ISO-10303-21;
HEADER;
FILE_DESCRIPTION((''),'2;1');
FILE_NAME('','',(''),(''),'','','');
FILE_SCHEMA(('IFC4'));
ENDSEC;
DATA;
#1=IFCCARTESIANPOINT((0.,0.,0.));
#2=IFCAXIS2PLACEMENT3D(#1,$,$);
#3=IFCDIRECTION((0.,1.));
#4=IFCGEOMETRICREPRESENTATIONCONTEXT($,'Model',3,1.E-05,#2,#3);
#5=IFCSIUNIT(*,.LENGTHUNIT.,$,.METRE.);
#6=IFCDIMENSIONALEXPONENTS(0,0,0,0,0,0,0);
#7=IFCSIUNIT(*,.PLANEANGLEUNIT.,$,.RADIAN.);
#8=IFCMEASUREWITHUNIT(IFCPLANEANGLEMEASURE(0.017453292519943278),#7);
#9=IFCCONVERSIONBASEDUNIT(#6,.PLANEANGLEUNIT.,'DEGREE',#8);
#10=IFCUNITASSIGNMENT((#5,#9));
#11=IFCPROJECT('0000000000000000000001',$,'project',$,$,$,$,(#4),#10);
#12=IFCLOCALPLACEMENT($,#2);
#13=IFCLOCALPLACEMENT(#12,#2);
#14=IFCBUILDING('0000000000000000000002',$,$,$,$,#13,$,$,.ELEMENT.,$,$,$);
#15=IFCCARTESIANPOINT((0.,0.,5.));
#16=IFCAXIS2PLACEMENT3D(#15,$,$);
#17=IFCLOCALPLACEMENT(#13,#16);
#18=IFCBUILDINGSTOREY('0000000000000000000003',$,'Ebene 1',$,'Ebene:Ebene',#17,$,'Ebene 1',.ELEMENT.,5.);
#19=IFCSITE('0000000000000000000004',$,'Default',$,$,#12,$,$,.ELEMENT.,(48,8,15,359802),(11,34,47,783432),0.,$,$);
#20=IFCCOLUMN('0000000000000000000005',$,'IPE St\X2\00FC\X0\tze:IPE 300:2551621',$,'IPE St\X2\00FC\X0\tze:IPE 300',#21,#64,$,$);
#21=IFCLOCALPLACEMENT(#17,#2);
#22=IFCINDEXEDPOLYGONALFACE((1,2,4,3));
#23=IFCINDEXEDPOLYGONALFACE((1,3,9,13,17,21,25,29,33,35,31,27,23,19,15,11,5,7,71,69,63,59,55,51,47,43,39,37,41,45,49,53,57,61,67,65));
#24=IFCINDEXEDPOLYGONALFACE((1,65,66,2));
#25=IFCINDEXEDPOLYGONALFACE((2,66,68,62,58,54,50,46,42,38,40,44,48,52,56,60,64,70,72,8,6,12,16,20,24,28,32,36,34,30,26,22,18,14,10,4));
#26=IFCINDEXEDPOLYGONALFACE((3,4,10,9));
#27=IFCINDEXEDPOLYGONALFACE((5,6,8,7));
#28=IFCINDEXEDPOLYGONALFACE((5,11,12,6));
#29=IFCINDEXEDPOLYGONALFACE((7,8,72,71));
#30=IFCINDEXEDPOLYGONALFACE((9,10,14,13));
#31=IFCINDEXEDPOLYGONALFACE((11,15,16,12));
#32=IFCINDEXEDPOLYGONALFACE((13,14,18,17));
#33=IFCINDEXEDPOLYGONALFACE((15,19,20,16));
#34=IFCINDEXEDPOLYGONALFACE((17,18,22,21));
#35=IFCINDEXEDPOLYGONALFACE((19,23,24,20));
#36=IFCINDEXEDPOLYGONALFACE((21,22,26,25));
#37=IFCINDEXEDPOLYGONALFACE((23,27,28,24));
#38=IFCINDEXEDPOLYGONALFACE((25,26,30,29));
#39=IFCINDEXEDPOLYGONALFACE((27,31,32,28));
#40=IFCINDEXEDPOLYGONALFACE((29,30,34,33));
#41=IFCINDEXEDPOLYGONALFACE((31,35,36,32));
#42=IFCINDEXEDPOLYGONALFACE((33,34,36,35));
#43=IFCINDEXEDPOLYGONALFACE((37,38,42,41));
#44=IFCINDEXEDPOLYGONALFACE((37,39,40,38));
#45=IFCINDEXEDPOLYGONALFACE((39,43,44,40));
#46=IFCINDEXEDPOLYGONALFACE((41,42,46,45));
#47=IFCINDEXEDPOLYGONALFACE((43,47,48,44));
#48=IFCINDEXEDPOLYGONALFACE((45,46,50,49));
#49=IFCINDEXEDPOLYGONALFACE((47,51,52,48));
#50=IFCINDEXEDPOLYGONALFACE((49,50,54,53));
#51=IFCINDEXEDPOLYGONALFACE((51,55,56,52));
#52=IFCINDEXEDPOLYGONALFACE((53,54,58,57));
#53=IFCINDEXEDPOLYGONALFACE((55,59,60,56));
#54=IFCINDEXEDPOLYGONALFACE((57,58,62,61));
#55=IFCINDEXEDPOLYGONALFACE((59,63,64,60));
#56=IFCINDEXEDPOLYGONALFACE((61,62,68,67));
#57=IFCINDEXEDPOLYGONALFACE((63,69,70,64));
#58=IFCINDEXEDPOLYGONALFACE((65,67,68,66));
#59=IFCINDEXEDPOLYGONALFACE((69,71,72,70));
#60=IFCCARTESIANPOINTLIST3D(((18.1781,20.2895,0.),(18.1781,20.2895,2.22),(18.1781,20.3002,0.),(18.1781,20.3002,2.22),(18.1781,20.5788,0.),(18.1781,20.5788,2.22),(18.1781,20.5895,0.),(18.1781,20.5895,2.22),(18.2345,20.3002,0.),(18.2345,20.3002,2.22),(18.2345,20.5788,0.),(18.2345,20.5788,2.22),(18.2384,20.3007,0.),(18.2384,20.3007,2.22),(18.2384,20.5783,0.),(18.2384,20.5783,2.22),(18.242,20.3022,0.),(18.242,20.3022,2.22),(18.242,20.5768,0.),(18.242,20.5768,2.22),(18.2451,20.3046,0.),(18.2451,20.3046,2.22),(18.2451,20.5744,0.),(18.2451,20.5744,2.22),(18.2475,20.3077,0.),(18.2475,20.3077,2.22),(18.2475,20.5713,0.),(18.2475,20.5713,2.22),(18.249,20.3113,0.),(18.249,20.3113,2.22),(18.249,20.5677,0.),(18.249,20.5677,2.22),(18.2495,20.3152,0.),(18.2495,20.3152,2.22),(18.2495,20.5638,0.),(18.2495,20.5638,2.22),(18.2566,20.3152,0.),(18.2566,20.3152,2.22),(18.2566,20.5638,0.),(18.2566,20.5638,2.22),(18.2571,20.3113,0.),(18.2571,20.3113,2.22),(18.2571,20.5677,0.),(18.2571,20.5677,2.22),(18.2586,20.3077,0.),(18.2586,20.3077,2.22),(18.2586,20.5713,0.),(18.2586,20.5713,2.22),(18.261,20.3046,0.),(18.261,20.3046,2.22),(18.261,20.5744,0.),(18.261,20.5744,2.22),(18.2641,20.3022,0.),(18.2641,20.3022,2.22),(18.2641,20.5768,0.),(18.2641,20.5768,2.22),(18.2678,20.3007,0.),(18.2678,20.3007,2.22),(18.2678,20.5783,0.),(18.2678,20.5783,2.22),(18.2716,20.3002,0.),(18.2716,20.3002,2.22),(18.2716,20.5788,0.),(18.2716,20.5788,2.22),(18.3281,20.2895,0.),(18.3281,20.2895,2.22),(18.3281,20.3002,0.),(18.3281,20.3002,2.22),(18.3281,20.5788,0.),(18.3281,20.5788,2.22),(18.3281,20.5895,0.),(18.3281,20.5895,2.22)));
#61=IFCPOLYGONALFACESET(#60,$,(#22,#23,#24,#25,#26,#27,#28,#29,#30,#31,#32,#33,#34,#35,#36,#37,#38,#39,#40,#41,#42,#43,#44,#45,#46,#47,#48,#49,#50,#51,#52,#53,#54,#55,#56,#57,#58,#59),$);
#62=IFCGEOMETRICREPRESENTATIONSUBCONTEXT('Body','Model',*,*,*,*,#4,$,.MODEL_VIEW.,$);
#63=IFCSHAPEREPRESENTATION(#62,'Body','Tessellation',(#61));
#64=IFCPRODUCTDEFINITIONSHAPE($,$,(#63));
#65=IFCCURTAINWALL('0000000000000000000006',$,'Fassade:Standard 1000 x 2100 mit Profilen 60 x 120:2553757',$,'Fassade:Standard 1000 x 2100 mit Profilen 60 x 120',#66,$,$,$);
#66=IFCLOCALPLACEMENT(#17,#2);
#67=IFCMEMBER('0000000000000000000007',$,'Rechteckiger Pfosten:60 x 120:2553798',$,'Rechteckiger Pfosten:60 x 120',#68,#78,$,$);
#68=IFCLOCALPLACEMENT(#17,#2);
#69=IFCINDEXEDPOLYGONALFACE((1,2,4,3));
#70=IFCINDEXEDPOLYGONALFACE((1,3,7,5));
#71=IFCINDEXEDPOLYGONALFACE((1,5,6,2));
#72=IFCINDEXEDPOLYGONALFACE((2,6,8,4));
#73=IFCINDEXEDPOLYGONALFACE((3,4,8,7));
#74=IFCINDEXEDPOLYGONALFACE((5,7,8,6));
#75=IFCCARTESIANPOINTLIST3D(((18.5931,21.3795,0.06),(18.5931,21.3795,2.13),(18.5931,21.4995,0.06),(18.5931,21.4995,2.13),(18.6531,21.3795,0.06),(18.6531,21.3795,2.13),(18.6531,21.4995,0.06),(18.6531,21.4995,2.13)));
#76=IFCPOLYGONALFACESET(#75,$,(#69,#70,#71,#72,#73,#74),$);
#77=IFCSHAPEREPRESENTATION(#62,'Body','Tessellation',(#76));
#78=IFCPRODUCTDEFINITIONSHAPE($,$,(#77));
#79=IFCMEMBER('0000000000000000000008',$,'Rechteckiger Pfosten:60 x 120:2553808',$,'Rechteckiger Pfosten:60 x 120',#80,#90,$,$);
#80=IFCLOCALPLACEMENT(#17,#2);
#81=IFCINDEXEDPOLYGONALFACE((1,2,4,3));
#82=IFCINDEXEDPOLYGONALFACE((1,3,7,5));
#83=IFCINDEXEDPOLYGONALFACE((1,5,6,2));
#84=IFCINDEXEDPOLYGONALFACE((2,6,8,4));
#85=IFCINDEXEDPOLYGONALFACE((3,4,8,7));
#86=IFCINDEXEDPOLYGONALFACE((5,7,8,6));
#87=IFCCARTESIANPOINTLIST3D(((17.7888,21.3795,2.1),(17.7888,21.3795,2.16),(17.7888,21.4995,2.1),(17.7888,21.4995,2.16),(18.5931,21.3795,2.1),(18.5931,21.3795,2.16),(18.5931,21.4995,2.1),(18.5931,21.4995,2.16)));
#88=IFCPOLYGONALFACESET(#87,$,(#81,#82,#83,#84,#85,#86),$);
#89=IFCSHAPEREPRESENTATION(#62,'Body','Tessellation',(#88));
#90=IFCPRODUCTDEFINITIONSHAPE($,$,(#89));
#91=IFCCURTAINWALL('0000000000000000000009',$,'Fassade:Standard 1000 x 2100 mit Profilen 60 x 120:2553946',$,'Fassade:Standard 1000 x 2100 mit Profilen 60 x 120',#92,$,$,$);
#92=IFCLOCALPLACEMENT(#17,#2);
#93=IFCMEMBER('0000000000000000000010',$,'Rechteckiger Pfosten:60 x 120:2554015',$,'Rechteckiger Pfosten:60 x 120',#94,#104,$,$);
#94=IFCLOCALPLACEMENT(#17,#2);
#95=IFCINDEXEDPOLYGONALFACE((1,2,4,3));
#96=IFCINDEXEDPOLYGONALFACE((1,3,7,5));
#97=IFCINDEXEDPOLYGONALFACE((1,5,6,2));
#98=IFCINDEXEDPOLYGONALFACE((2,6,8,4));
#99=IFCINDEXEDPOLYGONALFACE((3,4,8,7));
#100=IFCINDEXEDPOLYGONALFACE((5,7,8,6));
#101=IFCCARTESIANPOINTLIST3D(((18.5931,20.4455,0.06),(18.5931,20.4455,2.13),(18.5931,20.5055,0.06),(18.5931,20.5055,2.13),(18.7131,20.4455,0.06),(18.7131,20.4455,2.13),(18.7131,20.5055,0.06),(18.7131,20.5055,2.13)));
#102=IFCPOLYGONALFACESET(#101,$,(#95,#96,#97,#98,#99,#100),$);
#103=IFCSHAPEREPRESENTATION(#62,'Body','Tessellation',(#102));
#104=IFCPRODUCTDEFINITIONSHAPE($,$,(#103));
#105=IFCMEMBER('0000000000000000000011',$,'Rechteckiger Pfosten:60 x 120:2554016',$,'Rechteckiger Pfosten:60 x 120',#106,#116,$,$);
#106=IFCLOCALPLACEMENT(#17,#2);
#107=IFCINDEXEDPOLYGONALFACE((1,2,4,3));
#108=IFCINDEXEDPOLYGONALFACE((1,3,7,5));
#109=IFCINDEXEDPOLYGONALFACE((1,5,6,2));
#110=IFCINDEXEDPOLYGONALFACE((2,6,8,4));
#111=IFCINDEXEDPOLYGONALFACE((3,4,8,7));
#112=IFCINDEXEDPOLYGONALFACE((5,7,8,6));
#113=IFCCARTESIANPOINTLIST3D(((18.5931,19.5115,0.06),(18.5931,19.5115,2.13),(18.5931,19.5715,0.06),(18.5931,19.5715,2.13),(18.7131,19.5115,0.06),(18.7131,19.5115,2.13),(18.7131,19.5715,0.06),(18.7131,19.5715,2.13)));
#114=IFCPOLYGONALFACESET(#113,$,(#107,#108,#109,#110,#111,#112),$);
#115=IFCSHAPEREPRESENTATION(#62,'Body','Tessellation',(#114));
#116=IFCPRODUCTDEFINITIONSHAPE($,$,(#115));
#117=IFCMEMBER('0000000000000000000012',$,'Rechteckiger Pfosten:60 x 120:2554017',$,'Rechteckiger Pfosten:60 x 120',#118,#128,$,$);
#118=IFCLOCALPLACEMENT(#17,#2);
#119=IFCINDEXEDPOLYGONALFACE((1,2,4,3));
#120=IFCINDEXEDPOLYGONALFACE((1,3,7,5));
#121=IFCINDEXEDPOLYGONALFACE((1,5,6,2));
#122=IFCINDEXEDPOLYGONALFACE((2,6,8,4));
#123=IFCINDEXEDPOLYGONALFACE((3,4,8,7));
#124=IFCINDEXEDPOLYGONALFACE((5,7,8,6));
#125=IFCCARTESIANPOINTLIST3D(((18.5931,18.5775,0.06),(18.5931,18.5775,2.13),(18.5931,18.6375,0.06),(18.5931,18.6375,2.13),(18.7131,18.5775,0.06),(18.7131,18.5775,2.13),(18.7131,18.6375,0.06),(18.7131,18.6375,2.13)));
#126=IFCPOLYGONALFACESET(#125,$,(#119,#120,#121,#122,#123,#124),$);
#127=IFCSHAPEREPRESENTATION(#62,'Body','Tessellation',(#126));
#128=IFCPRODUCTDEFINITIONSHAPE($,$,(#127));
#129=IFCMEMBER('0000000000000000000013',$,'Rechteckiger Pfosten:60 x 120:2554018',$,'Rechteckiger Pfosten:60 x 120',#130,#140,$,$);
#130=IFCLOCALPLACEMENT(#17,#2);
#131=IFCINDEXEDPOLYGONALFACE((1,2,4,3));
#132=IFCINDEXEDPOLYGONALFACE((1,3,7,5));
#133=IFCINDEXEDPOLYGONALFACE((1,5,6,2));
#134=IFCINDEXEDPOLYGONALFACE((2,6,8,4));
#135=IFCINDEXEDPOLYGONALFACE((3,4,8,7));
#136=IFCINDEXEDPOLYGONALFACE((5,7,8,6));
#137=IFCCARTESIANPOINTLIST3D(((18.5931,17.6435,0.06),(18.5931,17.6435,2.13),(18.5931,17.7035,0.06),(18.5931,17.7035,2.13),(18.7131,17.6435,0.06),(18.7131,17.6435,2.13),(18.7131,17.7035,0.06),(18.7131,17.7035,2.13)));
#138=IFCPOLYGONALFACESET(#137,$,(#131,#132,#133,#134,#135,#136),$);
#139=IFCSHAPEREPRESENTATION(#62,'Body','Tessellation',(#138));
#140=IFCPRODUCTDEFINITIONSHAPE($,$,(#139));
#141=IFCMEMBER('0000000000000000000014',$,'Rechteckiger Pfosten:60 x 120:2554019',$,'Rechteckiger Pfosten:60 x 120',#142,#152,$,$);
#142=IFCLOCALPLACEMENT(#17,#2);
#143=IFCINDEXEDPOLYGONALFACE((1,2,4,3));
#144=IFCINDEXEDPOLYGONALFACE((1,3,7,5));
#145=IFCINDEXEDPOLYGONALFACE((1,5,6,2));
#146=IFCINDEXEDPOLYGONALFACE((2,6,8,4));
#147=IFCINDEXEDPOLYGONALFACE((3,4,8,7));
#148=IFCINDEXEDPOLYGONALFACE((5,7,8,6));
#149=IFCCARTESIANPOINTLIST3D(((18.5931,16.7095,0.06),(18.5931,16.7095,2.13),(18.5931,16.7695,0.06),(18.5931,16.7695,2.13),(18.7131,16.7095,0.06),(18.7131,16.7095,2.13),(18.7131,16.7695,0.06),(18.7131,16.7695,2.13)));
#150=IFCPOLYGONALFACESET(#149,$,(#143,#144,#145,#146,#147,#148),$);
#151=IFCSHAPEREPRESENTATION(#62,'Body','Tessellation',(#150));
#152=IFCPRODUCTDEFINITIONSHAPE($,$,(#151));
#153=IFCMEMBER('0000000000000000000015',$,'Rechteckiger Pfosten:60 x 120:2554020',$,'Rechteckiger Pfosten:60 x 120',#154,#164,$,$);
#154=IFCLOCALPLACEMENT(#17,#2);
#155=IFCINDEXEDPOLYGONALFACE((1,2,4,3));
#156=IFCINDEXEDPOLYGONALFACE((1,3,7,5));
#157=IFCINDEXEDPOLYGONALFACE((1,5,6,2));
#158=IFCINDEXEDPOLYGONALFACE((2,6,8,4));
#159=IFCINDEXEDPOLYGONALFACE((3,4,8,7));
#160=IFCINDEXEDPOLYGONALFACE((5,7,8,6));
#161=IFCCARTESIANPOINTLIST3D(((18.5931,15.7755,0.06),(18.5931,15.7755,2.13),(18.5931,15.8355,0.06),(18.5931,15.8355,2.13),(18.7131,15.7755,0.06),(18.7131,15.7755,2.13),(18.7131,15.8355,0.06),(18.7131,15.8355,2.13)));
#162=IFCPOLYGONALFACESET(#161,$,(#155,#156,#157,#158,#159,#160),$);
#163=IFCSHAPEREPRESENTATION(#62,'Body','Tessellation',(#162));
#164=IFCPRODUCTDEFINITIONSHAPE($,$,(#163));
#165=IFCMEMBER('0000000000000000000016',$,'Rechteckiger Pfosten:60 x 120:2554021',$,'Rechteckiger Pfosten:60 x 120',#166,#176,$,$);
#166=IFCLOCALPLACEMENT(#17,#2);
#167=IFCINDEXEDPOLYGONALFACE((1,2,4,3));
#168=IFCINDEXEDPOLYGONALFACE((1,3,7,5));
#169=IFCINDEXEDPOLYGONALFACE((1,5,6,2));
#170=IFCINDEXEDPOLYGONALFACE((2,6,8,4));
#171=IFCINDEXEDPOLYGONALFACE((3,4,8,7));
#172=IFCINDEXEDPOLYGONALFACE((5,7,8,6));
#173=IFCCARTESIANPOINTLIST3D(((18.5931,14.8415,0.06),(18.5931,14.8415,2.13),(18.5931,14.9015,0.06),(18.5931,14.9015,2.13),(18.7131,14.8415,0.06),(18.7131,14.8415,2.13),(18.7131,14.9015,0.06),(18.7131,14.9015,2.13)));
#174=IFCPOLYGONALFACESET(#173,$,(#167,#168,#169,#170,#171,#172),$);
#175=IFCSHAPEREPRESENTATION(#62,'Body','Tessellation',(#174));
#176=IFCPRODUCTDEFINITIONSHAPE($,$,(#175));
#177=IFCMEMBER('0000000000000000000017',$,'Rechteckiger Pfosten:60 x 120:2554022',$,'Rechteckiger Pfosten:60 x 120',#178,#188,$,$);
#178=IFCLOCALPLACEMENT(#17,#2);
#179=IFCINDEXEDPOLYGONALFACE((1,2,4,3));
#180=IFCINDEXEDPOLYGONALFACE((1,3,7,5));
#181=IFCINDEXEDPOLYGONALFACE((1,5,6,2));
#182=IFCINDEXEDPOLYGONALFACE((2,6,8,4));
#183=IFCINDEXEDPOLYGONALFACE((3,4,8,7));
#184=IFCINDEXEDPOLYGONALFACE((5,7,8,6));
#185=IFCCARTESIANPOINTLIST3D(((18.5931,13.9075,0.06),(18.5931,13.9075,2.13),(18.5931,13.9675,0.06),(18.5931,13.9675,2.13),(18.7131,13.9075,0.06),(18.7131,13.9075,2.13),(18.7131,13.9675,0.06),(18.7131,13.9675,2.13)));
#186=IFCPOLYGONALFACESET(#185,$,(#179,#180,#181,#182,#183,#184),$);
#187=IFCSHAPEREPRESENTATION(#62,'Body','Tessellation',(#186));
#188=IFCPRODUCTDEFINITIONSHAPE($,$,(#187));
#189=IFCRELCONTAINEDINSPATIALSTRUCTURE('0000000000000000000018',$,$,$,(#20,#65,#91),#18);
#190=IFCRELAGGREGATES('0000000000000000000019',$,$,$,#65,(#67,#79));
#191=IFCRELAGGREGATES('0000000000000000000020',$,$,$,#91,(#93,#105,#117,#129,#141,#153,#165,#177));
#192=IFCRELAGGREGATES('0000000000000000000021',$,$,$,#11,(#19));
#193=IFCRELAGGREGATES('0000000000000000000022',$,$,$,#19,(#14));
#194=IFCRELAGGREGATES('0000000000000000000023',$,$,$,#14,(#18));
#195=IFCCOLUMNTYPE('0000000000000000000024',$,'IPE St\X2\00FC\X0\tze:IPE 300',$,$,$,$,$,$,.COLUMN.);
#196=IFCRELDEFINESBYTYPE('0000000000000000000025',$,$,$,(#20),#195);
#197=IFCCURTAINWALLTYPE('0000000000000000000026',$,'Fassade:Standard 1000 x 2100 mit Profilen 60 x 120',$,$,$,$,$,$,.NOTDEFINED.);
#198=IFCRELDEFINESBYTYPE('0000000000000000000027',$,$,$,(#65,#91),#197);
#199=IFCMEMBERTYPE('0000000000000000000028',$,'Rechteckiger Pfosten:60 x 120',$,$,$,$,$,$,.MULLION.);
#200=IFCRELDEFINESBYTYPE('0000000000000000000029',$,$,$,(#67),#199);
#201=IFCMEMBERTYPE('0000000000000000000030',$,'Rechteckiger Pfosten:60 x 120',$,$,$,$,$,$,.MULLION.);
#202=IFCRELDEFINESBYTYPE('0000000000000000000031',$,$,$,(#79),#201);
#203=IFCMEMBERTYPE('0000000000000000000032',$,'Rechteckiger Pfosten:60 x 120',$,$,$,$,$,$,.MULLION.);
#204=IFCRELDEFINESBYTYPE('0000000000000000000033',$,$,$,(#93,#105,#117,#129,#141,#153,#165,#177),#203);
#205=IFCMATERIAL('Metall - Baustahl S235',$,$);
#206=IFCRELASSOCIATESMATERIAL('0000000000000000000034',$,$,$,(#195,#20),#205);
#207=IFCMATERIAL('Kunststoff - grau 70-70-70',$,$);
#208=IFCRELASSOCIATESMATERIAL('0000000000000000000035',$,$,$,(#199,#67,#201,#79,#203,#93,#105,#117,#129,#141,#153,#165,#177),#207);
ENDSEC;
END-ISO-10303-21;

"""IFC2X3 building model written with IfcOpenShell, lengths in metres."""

from ifc_helpers import new_model, entity, si_unit, converted_unit, direction, frame, frame_2d, origin, origin_2d_with_axis, place, context, subcontext, project, spatial, rectangle, i_section, extrude, source, transform, mapped, material, type_object, type_shapes, element, aggregate, save


model = new_model("IFC2X3")

# Units and contexts
model_context = context("Model", 3, precision=1e-05, world=origin(), true_north=direction((0.0, 1.0)))
body_context = subcontext(model_context, "Body", "Model", "MODEL_VIEW")
ifc_project = project(units=[si_unit("LENGTHUNIT", "METRE"), converted_unit("PLANEANGLEUNIT", "DEGREE", entity("IfcPlaneAngleMeasure", 0.017453292519943278), si_unit("PLANEANGLEUNIT", "RADIAN"), dimensions=[0, 0, 0, 0, 0, 0, 0])], contexts=[model_context])

# Site, building, storey
site_placement = place(None, origin())
site = spatial("IfcSite", under=ifc_project, at=site_placement, Name="Default", CompositionType="ELEMENT", RefLatitude=(48, 8, 15, 359802), RefLongitude=(11, 34, 47, 783432), RefElevation=0.0)
building_placement = place(site_placement, origin())
building = spatial("IfcBuilding", under=site, at=building_placement, CompositionType="ELEMENT")
storey_placement = place(building_placement, frame((0.0, 0.0, 5.0)))
storey = spatial("IfcBuildingStorey", under=building, at=storey_placement, Name="Ebene 1", ObjectType="Ebene:Ebene", LongName="Ebene 1", CompositionType="ELEMENT", Elevation=5.0)

# Column
ifc_material_1 = material(Name="Metall - Baustahl S235")
column_type = type_object("IfcColumnType", Name="IPE Stütze:IPE 300", PredefinedType="COLUMN", material=ifc_material_1)
shared_shape_1 = source(origin(), body_context, "Body", "SweptSolid", [
    extrude(i_section(OverallWidth=0.15, OverallDepth=0.3, WebThickness=0.0071, FlangeThickness=0.0107, FilletRadius=0.015, at=origin_2d_with_axis()), frame((0.0, 0.0, 5.0), z_axis=(0.0, 0.0, 1.0), x_axis=(-1.0, 0.0, 0.0)), (0.0, 0.0, 1.0), 2.22),
])
type_shapes(column_type, [shared_shape_1])
column_placement = place(storey_placement, frame((18.2531, 20.4395, -5.0)))
element("IfcColumn", 1, at=column_placement, inside=storey, type_object=column_type, material=ifc_material_1, Name="IPE Stütze:IPE 300:2551621", ObjectType="IPE Stütze:IPE 300", context=body_context, shape_type="MappedRepresentation", body=[
    mapped(shared_shape_1, transform((0.0, 0.0, 0.0), scale=1.0)),
])

# Curtain walls, members
curtain_wall_type = type_object("IfcCurtainWallType", Name="Fassade:Standard 1000 x 2100 mit Profilen 60 x 120", PredefinedType="NOTDEFINED")
curtain_wall_1_placement = place(storey_placement, frame((0.0, 0.0, -5.0)))
curtain_wall_1 = element("IfcCurtainWall", 2, at=curtain_wall_1_placement, inside=storey, type_object=curtain_wall_type, Name="Fassade:Standard 1000 x 2100 mit Profilen 60 x 120:2553757", ObjectType="Fassade:Standard 1000 x 2100 mit Profilen 60 x 120")
ifc_material_2 = material(Name="Kunststoff - grau 70-70-70")
member_type_1 = type_object("IfcMemberType", Name="Rechteckiger Pfosten:60 x 120", PredefinedType="MULLION", material=ifc_material_2)
shared_shape_2 = source(origin(), body_context, "Body", "SweptSolid", [
    extrude(rectangle(XDim=0.06, YDim=0.12, at=origin_2d_with_axis()), frame((-0.03, 0.0, -2.07), z_axis=(0.0, 0.0, 1.0), x_axis=(-1.0, 0.0, 0.0)), (0.0, 0.0, 1.0), 2.07),
])
type_shapes(member_type_1, [shared_shape_2])
member_1_placement = place(curtain_wall_1_placement, frame((18.6531, 21.4395, 5.06), z_axis=(0.0, 0.0, -1.0), x_axis=(1.0, 0.0, 0.0)))
member_1 = element("IfcMember", 3, at=member_1_placement, type_object=member_type_1, material=ifc_material_2, Name="Rechteckiger Pfosten:60 x 120:2553798", ObjectType="Rechteckiger Pfosten:60 x 120", context=body_context, shape_type="MappedRepresentation", body=[
    mapped(shared_shape_2, transform((0.0, 0.0, 0.0), scale=1.0)),
])
member_type_2 = type_object("IfcMemberType", Name="Rechteckiger Pfosten:60 x 120", PredefinedType="MULLION", material=ifc_material_2)
shared_shape_3 = source(origin(), body_context, "Body", "SweptSolid", [
    extrude(rectangle(XDim=0.06, YDim=0.12, at=frame_2d((0.0, 0.0), x_axis=(1.0, 0.0))), frame((0.0, 0.0, -0.8043), z_axis=(0.0, 0.0, 1.0), x_axis=(-1.0, 0.0, 0.0)), (0.0, 0.0, 1.0), 0.8043),
])
type_shapes(member_type_2, [shared_shape_3])
member_2_placement = place(curtain_wall_1_placement, frame((18.5931, 21.4395, 7.13), z_axis=(1.0, 0.0, 0.0), x_axis=(0.0, 0.0, 1.0)))
member_2 = element("IfcMember", 4, at=member_2_placement, type_object=member_type_2, material=ifc_material_2, Name="Rechteckiger Pfosten:60 x 120:2553808", ObjectType="Rechteckiger Pfosten:60 x 120", context=body_context, shape_type="MappedRepresentation", body=[
    mapped(shared_shape_3, transform((0.0, 0.0, 0.0), scale=1.0)),
])
curtain_wall_2_placement = place(storey_placement, frame((0.0, 0.0, -5.0)))
curtain_wall_2 = element("IfcCurtainWall", 5, at=curtain_wall_2_placement, inside=storey, type_object=curtain_wall_type, Name="Fassade:Standard 1000 x 2100 mit Profilen 60 x 120:2553946", ObjectType="Fassade:Standard 1000 x 2100 mit Profilen 60 x 120")
member_type_3 = type_object("IfcMemberType", Name="Rechteckiger Pfosten:60 x 120", PredefinedType="MULLION", material=ifc_material_2)
shared_shape_4 = source(origin(), body_context, "Body", "SweptSolid", [
    extrude(rectangle(XDim=0.06, YDim=0.12, at=origin_2d_with_axis()), frame((0.0, 0.0, -2.07), z_axis=(0.0, 0.0, 1.0), x_axis=(-1.0, 0.0, 0.0)), (0.0, 0.0, 1.0), 2.07),
])
type_shapes(member_type_3, [shared_shape_4])
member_3_placement = place(curtain_wall_2_placement, frame((18.6531, 20.4755, 5.06), z_axis=(0.0, 0.0, -1.0), x_axis=(0.0, -1.0, 0.0)))
member_3 = element("IfcMember", 6, at=member_3_placement, type_object=member_type_3, material=ifc_material_2, Name="Rechteckiger Pfosten:60 x 120:2554015", ObjectType="Rechteckiger Pfosten:60 x 120", context=body_context, shape_type="MappedRepresentation", body=[
    mapped(shared_shape_4, transform((0.0, 0.0, 0.0), scale=1.0)),
])
member_4_placement = place(curtain_wall_2_placement, frame((18.6531, 19.5415, 5.06), z_axis=(0.0, 0.0, -1.0), x_axis=(0.0, -1.0, 0.0)))
member_4 = element("IfcMember", 7, at=member_4_placement, type_object=member_type_3, material=ifc_material_2, Name="Rechteckiger Pfosten:60 x 120:2554016", ObjectType="Rechteckiger Pfosten:60 x 120", context=body_context, shape_type="MappedRepresentation", body=[
    mapped(shared_shape_4, transform((0.0, 0.0, 0.0), scale=1.0)),
])
member_5_placement = place(curtain_wall_2_placement, frame((18.6531, 18.6075, 5.06), z_axis=(0.0, 0.0, -1.0), x_axis=(0.0, -1.0, 0.0)))
member_5 = element("IfcMember", 8, at=member_5_placement, type_object=member_type_3, material=ifc_material_2, Name="Rechteckiger Pfosten:60 x 120:2554017", ObjectType="Rechteckiger Pfosten:60 x 120", context=body_context, shape_type="MappedRepresentation", body=[
    mapped(shared_shape_4, transform((0.0, 0.0, 0.0), scale=1.0)),
])
member_6_placement = place(curtain_wall_2_placement, frame((18.6531, 17.6735, 5.06), z_axis=(0.0, 0.0, -1.0), x_axis=(0.0, -1.0, 0.0)))
member_6 = element("IfcMember", 9, at=member_6_placement, type_object=member_type_3, material=ifc_material_2, Name="Rechteckiger Pfosten:60 x 120:2554018", ObjectType="Rechteckiger Pfosten:60 x 120", context=body_context, shape_type="MappedRepresentation", body=[
    mapped(shared_shape_4, transform((0.0, 0.0, 0.0), scale=1.0)),
])
member_7_placement = place(curtain_wall_2_placement, frame((18.6531, 16.7395, 5.06), z_axis=(0.0, 0.0, -1.0), x_axis=(0.0, -1.0, 0.0)))
member_7 = element("IfcMember", 10, at=member_7_placement, type_object=member_type_3, material=ifc_material_2, Name="Rechteckiger Pfosten:60 x 120:2554019", ObjectType="Rechteckiger Pfosten:60 x 120", context=body_context, shape_type="MappedRepresentation", body=[
    mapped(shared_shape_4, transform((0.0, 0.0, 0.0), scale=1.0)),
])
member_8_placement = place(curtain_wall_2_placement, frame((18.6531, 15.8055, 5.06), z_axis=(0.0, 0.0, -1.0), x_axis=(0.0, -1.0, 0.0)))
member_8 = element("IfcMember", 11, at=member_8_placement, type_object=member_type_3, material=ifc_material_2, Name="Rechteckiger Pfosten:60 x 120:2554020", ObjectType="Rechteckiger Pfosten:60 x 120", context=body_context, shape_type="MappedRepresentation", body=[
    mapped(shared_shape_4, transform((0.0, 0.0, 0.0), scale=1.0)),
])
member_9_placement = place(curtain_wall_2_placement, frame((18.6531, 14.8715, 5.06), z_axis=(0.0, 0.0, -1.0), x_axis=(0.0, -1.0, 0.0)))
member_9 = element("IfcMember", 12, at=member_9_placement, type_object=member_type_3, material=ifc_material_2, Name="Rechteckiger Pfosten:60 x 120:2554021", ObjectType="Rechteckiger Pfosten:60 x 120", context=body_context, shape_type="MappedRepresentation", body=[
    mapped(shared_shape_4, transform((0.0, 0.0, 0.0), scale=1.0)),
])
member_10_placement = place(curtain_wall_2_placement, frame((18.6531, 13.9375, 5.06), z_axis=(0.0, 0.0, -1.0), x_axis=(0.0, -1.0, 0.0)))
member_10 = element("IfcMember", 13, at=member_10_placement, type_object=member_type_3, material=ifc_material_2, Name="Rechteckiger Pfosten:60 x 120:2554022", ObjectType="Rechteckiger Pfosten:60 x 120", context=body_context, shape_type="MappedRepresentation", body=[
    mapped(shared_shape_4, transform((0.0, 0.0, 0.0), scale=1.0)),
])

aggregate(curtain_wall_1, [member_1, member_2])
aggregate(curtain_wall_2, [member_3, member_4, member_5, member_6, member_7, member_8, member_9, member_10])

save(model, "model.ifc")
